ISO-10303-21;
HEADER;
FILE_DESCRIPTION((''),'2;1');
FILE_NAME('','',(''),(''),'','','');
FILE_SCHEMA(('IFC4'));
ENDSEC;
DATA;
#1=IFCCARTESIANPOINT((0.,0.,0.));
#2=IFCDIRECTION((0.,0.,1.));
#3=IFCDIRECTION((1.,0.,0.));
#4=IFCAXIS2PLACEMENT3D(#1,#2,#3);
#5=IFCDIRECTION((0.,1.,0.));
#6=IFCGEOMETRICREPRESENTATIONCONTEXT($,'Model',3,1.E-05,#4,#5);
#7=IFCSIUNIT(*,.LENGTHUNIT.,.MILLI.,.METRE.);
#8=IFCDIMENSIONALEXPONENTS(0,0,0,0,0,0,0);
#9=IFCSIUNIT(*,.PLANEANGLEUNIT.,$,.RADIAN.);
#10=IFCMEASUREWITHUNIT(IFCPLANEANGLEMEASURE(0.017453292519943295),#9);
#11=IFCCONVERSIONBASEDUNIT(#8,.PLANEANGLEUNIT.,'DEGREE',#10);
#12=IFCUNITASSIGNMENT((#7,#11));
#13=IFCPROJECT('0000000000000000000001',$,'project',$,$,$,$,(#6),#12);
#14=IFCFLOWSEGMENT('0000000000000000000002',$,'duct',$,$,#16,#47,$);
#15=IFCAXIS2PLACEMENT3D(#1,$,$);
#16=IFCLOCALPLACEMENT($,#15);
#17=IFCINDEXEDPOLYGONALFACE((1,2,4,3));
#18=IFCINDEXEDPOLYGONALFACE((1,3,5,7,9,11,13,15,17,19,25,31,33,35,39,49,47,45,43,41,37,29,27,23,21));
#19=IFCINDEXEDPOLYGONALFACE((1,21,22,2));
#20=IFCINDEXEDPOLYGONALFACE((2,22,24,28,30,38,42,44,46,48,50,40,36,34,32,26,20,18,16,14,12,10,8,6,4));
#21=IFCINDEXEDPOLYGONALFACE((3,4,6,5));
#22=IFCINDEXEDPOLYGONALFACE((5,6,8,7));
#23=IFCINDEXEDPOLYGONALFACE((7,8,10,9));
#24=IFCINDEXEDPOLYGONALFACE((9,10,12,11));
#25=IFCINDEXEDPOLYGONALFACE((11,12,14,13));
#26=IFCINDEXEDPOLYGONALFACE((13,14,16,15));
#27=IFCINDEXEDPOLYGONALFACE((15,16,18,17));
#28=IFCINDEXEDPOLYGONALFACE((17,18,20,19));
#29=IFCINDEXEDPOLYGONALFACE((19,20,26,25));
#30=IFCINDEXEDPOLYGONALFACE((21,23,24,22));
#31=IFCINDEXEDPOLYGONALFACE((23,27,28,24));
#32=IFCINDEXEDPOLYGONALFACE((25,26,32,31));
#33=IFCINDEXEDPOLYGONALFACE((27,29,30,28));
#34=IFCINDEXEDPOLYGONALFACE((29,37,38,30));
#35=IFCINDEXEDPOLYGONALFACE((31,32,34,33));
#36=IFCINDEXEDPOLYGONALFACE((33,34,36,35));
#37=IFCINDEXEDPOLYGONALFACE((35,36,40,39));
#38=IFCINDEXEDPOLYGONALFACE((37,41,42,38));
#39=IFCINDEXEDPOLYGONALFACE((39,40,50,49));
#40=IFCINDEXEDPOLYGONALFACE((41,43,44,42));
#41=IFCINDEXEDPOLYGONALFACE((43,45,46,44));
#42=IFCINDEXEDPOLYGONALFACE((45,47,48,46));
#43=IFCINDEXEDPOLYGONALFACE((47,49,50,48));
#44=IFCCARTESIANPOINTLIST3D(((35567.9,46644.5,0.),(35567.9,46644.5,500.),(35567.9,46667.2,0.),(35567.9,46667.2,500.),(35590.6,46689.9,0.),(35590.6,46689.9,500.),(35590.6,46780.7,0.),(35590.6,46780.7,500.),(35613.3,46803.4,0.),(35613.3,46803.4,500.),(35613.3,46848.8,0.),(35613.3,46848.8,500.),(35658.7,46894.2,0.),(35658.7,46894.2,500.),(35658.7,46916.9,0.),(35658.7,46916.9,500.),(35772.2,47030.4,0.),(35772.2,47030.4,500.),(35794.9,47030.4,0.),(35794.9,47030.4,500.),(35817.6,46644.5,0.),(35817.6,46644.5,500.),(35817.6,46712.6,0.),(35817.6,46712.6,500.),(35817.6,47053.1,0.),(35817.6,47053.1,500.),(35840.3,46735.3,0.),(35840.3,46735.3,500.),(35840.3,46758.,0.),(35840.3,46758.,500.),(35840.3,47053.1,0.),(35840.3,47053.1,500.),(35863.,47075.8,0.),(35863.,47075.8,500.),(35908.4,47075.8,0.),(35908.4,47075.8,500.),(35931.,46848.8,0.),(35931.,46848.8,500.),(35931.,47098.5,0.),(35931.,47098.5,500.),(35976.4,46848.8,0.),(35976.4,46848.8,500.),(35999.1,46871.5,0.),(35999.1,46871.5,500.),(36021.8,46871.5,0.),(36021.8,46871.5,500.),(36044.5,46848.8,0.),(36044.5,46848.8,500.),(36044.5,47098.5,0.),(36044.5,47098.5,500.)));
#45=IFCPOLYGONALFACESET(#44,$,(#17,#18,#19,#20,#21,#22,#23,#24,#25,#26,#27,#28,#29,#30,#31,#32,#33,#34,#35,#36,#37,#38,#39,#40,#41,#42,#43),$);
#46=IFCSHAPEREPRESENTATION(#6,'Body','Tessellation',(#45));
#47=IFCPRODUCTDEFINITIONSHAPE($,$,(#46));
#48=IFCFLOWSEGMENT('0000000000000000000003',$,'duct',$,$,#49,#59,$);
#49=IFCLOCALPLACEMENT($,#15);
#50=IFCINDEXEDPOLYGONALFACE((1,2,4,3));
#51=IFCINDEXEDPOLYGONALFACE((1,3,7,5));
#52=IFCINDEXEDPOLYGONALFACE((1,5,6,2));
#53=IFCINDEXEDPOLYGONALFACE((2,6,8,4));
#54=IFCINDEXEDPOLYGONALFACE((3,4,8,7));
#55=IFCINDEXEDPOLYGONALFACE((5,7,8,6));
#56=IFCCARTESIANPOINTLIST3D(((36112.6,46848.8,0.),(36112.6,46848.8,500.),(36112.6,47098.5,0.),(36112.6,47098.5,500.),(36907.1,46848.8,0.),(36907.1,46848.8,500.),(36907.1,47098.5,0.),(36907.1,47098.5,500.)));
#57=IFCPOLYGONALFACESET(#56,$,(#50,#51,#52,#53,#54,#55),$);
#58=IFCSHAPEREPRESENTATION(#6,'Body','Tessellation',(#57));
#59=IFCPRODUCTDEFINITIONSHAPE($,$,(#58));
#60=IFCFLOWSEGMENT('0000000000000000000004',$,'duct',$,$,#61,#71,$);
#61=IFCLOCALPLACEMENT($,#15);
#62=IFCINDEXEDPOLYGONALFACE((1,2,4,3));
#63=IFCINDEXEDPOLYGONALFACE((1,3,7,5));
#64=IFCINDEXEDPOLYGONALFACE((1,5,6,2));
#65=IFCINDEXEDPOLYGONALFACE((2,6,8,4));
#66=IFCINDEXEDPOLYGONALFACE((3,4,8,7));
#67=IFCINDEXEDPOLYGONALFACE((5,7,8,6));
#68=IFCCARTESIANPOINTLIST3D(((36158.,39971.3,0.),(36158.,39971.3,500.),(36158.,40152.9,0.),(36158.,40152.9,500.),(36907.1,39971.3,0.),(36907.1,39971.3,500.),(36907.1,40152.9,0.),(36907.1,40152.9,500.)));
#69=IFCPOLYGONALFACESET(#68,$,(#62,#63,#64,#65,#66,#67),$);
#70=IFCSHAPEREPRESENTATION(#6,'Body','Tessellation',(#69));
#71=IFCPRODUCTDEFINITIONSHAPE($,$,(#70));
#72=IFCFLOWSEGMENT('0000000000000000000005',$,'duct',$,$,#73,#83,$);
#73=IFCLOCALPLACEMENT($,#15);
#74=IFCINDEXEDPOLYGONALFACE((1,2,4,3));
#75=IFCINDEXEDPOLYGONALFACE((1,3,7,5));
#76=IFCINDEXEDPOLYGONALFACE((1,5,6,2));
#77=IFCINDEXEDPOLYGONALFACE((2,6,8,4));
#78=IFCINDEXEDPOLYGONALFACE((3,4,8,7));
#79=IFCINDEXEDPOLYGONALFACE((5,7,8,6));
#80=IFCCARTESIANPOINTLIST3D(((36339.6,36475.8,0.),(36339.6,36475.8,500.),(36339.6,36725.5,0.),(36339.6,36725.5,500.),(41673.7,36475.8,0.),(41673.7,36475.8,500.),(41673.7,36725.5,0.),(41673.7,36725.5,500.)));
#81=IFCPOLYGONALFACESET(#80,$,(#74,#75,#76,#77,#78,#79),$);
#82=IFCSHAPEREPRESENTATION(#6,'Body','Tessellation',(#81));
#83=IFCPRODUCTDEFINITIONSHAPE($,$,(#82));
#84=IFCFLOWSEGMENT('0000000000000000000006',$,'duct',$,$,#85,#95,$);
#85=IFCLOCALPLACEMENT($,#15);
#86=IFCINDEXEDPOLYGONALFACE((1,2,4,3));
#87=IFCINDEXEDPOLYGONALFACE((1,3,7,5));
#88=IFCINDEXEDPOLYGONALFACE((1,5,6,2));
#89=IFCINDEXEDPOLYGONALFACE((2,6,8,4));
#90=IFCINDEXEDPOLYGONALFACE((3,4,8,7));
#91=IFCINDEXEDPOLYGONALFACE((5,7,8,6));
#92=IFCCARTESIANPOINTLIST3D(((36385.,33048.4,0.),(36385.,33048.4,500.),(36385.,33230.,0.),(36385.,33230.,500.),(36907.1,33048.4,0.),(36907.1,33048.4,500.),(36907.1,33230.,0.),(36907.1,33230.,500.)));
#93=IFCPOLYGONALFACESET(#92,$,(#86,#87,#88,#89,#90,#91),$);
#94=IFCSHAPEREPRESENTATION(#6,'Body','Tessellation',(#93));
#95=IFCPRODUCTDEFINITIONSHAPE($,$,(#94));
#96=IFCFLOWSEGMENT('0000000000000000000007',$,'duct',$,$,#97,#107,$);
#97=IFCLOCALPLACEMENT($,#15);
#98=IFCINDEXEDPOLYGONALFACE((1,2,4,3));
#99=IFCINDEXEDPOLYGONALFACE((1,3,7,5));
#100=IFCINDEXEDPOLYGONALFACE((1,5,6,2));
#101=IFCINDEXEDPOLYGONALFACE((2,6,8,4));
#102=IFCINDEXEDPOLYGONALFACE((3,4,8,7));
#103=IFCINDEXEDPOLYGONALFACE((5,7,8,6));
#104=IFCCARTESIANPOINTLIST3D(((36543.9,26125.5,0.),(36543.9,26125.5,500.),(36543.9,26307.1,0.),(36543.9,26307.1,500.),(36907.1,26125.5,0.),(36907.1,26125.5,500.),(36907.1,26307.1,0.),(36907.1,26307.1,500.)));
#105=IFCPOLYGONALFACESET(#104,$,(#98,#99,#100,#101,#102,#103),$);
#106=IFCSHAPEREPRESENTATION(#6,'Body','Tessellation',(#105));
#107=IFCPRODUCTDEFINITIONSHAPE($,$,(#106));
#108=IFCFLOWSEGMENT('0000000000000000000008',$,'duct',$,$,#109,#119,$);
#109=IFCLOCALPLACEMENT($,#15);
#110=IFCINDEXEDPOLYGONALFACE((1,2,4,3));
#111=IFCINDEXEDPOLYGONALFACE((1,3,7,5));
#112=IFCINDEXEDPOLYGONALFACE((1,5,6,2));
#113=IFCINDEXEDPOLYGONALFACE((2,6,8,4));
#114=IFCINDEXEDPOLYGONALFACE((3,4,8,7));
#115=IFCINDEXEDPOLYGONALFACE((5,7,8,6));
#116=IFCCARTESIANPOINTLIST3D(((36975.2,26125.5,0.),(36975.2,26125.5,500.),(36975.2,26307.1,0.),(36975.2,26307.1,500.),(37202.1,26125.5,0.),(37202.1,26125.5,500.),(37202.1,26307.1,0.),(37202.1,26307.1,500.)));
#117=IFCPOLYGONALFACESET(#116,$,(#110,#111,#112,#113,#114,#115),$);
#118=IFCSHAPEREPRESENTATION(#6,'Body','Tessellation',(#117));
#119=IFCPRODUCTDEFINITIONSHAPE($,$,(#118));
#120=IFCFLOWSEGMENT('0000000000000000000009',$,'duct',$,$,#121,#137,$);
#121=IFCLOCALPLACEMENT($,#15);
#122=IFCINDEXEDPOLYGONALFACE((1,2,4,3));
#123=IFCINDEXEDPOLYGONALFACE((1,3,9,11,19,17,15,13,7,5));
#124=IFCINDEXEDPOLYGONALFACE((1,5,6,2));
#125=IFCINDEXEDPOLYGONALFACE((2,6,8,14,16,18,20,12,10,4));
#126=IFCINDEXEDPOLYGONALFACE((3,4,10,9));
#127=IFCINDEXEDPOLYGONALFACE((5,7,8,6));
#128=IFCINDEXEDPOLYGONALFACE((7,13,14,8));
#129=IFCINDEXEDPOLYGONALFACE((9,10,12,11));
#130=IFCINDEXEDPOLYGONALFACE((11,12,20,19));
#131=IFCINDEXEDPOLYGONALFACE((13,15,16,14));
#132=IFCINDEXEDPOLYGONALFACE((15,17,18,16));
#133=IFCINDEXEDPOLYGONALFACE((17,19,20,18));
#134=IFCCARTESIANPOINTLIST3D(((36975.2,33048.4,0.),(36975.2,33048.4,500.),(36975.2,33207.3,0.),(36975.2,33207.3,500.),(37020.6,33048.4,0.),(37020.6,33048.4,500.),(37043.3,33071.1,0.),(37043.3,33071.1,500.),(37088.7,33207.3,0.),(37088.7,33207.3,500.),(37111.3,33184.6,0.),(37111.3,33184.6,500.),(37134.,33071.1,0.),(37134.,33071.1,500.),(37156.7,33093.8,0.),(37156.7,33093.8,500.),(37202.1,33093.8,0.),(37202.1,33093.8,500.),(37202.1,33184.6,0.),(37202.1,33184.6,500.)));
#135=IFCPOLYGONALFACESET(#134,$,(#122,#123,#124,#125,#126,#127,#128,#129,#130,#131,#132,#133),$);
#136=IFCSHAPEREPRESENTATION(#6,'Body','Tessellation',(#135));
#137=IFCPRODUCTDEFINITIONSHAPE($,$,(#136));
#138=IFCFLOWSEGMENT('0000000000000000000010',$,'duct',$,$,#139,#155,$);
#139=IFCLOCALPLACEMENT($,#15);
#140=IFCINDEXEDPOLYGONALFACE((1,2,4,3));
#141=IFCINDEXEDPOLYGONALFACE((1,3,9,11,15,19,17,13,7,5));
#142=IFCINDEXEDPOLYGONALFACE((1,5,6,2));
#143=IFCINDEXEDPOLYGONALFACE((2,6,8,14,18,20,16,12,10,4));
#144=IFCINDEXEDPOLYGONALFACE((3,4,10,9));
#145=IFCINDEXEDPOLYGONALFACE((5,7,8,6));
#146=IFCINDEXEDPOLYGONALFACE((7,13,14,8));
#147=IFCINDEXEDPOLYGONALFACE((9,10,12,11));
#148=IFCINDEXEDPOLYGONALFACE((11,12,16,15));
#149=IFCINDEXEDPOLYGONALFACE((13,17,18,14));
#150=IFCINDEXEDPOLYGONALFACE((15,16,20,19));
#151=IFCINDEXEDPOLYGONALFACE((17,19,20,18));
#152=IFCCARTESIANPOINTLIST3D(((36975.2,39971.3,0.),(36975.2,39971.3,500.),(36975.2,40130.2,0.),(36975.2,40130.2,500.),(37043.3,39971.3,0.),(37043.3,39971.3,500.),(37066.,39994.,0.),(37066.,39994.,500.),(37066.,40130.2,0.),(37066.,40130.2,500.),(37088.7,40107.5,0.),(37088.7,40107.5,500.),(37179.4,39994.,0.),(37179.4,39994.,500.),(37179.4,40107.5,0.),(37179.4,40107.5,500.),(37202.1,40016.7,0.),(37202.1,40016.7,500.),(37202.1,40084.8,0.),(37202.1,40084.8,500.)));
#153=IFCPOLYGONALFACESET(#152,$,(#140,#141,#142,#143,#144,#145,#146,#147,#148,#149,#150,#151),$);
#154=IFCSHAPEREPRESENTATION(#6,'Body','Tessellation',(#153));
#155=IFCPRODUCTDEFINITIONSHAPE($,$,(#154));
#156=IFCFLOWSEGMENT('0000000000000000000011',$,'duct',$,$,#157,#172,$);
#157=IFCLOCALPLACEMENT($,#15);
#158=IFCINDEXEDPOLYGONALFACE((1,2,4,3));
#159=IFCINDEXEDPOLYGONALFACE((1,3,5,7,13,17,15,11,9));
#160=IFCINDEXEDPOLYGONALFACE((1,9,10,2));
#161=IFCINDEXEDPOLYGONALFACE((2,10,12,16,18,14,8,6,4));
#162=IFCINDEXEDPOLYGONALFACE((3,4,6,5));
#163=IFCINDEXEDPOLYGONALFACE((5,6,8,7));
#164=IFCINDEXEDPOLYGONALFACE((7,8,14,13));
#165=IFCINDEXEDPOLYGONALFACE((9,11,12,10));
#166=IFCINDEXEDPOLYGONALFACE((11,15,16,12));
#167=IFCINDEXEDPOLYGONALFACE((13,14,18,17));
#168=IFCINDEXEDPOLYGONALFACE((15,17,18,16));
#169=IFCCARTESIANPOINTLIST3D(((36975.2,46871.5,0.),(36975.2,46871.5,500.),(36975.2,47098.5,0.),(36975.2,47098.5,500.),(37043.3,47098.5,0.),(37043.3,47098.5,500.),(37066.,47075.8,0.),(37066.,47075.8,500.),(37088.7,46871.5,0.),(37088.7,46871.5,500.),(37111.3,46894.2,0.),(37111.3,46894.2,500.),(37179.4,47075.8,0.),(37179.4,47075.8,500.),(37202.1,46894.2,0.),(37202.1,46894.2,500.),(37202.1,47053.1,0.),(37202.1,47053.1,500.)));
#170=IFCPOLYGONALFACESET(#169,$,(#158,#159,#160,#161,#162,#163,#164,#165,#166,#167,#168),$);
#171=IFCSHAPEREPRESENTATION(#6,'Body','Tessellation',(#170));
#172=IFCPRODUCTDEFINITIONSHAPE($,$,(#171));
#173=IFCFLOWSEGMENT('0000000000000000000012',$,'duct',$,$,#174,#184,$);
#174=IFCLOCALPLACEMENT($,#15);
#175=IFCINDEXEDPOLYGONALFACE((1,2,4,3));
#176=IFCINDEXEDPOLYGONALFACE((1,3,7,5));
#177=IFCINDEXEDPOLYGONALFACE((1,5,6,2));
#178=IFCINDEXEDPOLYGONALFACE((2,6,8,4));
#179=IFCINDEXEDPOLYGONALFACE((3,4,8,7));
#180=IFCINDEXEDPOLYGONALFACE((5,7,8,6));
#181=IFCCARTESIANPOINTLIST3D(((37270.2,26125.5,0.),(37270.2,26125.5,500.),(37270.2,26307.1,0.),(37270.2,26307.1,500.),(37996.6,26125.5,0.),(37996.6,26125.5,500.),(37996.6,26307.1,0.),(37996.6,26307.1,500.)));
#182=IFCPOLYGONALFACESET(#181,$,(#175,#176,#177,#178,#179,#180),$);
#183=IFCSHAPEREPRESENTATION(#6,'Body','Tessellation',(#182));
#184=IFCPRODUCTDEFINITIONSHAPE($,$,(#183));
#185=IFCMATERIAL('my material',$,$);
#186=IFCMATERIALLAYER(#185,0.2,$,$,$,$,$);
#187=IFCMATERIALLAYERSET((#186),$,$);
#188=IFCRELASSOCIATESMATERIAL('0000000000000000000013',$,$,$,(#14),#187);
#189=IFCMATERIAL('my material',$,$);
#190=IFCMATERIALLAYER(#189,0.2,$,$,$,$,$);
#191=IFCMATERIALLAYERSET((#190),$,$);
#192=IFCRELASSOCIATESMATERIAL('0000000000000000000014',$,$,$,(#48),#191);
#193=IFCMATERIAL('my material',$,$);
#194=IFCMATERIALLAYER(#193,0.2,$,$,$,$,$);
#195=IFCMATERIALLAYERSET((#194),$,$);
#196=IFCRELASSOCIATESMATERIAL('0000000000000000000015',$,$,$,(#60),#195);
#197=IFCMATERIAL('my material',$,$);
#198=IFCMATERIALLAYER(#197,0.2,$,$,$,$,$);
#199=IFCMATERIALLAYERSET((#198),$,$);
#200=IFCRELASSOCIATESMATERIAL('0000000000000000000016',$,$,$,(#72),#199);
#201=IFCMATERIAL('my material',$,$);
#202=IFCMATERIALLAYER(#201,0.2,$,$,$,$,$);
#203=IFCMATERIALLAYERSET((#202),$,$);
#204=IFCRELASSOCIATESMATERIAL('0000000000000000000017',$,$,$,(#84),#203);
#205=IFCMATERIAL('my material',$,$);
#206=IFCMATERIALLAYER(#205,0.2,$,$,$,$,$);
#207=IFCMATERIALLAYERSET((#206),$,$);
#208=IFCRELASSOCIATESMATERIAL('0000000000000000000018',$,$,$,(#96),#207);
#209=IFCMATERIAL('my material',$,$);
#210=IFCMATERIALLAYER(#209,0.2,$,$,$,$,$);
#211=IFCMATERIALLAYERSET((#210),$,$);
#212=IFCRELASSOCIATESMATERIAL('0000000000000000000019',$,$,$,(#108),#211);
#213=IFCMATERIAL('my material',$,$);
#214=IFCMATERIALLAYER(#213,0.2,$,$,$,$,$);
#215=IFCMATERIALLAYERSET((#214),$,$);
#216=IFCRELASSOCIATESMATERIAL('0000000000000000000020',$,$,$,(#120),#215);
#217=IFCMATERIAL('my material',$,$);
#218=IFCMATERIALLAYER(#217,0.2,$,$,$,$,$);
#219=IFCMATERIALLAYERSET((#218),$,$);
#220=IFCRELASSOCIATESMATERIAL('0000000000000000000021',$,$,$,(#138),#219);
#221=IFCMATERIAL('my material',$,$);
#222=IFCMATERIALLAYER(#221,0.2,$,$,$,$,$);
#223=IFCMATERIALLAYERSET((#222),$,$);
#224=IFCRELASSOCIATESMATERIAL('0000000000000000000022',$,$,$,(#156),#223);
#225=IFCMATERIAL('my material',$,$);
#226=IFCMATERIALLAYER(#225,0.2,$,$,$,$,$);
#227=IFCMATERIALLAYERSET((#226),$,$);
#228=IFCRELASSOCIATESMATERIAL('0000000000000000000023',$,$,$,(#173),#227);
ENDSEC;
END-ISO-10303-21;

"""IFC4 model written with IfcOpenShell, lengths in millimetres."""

from ifc_helpers import new_model, entity, si_unit, converted_unit, direction, origin_with_axes, place, context, project, polyline, outline, extrude, material, layer, layer_set, layer_usage, element, save


model = new_model("IFC4")

# Units and contexts
model_context = context("Model", 3, precision=1e-05, world=origin_with_axes(), true_north=direction((0.0, 1.0, 0.0)))
ifc_project = project(units=[si_unit("LENGTHUNIT", "METRE", prefix="MILLI"), converted_unit("PLANEANGLEUNIT", "DEGREE", entity("IfcPlaneAngleMeasure", 0.017453292519943295), si_unit("PLANEANGLEUNIT", "RADIAN"), dimensions=[0, 0, 0, 0, 0, 0, 0])], contexts=[model_context])

# Flow segments
ifc_material_1 = material(Name="my material")
ifc_layer_1 = layer(ifc_material_1, 0.2)
ifc_layer_set_1 = layer_set([ifc_layer_1])
ifc_layer_usage_1 = layer_usage(ifc_layer_set_1, "AXIS2", "POSITIVE", -0.1)
flow_segment_1_placement = place(None, origin_with_axes())
element("IfcFlowSegment", 1, at=flow_segment_1_placement, material=ifc_layer_usage_1, Name="duct", context=model_context, shape_type="SweptSolid", body=[
    extrude(outline(polyline([(35567.9, 46644.5), (35817.6, 46644.5), (35817.6, 46712.6), (35840.3, 46735.3), (35840.3, 46758.0), (35931.0, 46848.8), (35976.4, 46848.8), (35999.1, 46871.5), (36021.8, 46871.5), (36044.5, 46848.8), (36044.5, 47098.5), (35931.0, 47098.5), (35908.4, 47075.8), (35863.0, 47075.8), (35840.3, 47053.1), (35817.6, 47053.1), (35794.9, 47030.4), (35772.2, 47030.4), (35658.7, 46916.9), (35658.7, 46894.2), (35613.3, 46848.8), (35613.3, 46803.4), (35590.6, 46780.7), (35590.6, 46689.9), (35567.9, 46667.2), (35567.9, 46644.5)])), origin_with_axes(), (0.0, 0.0, 1.0), 500.0),
])
ifc_material_2 = material(Name="my material")
ifc_layer_2 = layer(ifc_material_2, 0.2)
ifc_layer_set_2 = layer_set([ifc_layer_2])
ifc_layer_usage_2 = layer_usage(ifc_layer_set_2, "AXIS2", "POSITIVE", -0.1)
flow_segment_2_placement = place(None, origin_with_axes())
element("IfcFlowSegment", 2, at=flow_segment_2_placement, material=ifc_layer_usage_2, Name="duct", context=model_context, shape_type="SweptSolid", body=[
    extrude(outline(polyline([(36112.6, 46848.8), (36907.1, 46848.8), (36907.1, 47098.5), (36112.6, 47098.5), (36112.6, 46848.8)])), origin_with_axes(), (0.0, 0.0, 1.0), 500.0),
])
ifc_material_3 = material(Name="my material")
ifc_layer_3 = layer(ifc_material_3, 0.2)
ifc_layer_set_3 = layer_set([ifc_layer_3])
ifc_layer_usage_3 = layer_usage(ifc_layer_set_3, "AXIS2", "POSITIVE", -0.1)
flow_segment_3_placement = place(None, origin_with_axes())
element("IfcFlowSegment", 3, at=flow_segment_3_placement, material=ifc_layer_usage_3, Name="duct", context=model_context, shape_type="SweptSolid", body=[
    extrude(outline(polyline([(36158.0, 39971.3), (36907.1, 39971.3), (36907.1, 40152.9), (36158.0, 40152.9), (36158.0, 39971.3)])), origin_with_axes(), (0.0, 0.0, 1.0), 500.0),
])
ifc_material_4 = material(Name="my material")
ifc_layer_4 = layer(ifc_material_4, 0.2)
ifc_layer_set_4 = layer_set([ifc_layer_4])
ifc_layer_usage_4 = layer_usage(ifc_layer_set_4, "AXIS2", "POSITIVE", -0.1)
flow_segment_4_placement = place(None, origin_with_axes())
element("IfcFlowSegment", 4, at=flow_segment_4_placement, material=ifc_layer_usage_4, Name="duct", context=model_context, shape_type="SweptSolid", body=[
    extrude(outline(polyline([(36339.6, 36475.8), (41673.7, 36475.8), (41673.7, 36725.5), (36339.6, 36725.5), (36339.6, 36475.8)])), origin_with_axes(), (0.0, 0.0, 1.0), 500.0),
])
ifc_material_5 = material(Name="my material")
ifc_layer_5 = layer(ifc_material_5, 0.2)
ifc_layer_set_5 = layer_set([ifc_layer_5])
ifc_layer_usage_5 = layer_usage(ifc_layer_set_5, "AXIS2", "POSITIVE", -0.1)
flow_segment_5_placement = place(None, origin_with_axes())
element("IfcFlowSegment", 5, at=flow_segment_5_placement, material=ifc_layer_usage_5, Name="duct", context=model_context, shape_type="SweptSolid", body=[
    extrude(outline(polyline([(36385.0, 33048.4), (36907.1, 33048.4), (36907.1, 33230.0), (36385.0, 33230.0), (36385.0, 33048.4)])), origin_with_axes(), (0.0, 0.0, 1.0), 500.0),
])
ifc_material_6 = material(Name="my material")
ifc_layer_6 = layer(ifc_material_6, 0.2)
ifc_layer_set_6 = layer_set([ifc_layer_6])
ifc_layer_usage_6 = layer_usage(ifc_layer_set_6, "AXIS2", "POSITIVE", -0.1)
flow_segment_6_placement = place(None, origin_with_axes())
element("IfcFlowSegment", 6, at=flow_segment_6_placement, material=ifc_layer_usage_6, Name="duct", context=model_context, shape_type="SweptSolid", body=[
    extrude(outline(polyline([(36543.9, 26125.5), (36907.1, 26125.5), (36907.1, 26307.1), (36543.9, 26307.1), (36543.9, 26125.5)])), origin_with_axes(), (0.0, 0.0, 1.0), 500.0),
])
ifc_material_7 = material(Name="my material")
ifc_layer_7 = layer(ifc_material_7, 0.2)
ifc_layer_set_7 = layer_set([ifc_layer_7])
ifc_layer_usage_7 = layer_usage(ifc_layer_set_7, "AXIS2", "POSITIVE", -0.1)
flow_segment_7_placement = place(None, origin_with_axes())
element("IfcFlowSegment", 7, at=flow_segment_7_placement, material=ifc_layer_usage_7, Name="duct", context=model_context, shape_type="SweptSolid", body=[
    extrude(outline(polyline([(36975.2, 26125.5), (37202.1, 26125.5), (37202.1, 26307.1), (36975.2, 26307.1), (36975.2, 26125.5)])), origin_with_axes(), (0.0, 0.0, 1.0), 500.0),
])
ifc_material_8 = material(Name="my material")
ifc_layer_8 = layer(ifc_material_8, 0.2)
ifc_layer_set_8 = layer_set([ifc_layer_8])
ifc_layer_usage_8 = layer_usage(ifc_layer_set_8, "AXIS2", "POSITIVE", -0.1)
flow_segment_8_placement = place(None, origin_with_axes())
element("IfcFlowSegment", 8, at=flow_segment_8_placement, material=ifc_layer_usage_8, Name="duct", context=model_context, shape_type="SweptSolid", body=[
    extrude(outline(polyline([(36975.2, 33048.4), (37020.6, 33048.4), (37043.3, 33071.1), (37134.0, 33071.1), (37156.7, 33093.8), (37202.1, 33093.8), (37202.1, 33184.6), (37111.3, 33184.6), (37088.7, 33207.3), (36975.2, 33207.3), (36975.2, 33048.4)])), origin_with_axes(), (0.0, 0.0, 1.0), 500.0),
])
ifc_material_9 = material(Name="my material")
ifc_layer_9 = layer(ifc_material_9, 0.2)
ifc_layer_set_9 = layer_set([ifc_layer_9])
ifc_layer_usage_9 = layer_usage(ifc_layer_set_9, "AXIS2", "POSITIVE", -0.1)
flow_segment_9_placement = place(None, origin_with_axes())
element("IfcFlowSegment", 9, at=flow_segment_9_placement, material=ifc_layer_usage_9, Name="duct", context=model_context, shape_type="SweptSolid", body=[
    extrude(outline(polyline([(36975.2, 39971.3), (37043.3, 39971.3), (37066.0, 39994.0), (37179.4, 39994.0), (37202.1, 40016.7), (37202.1, 40084.8), (37179.4, 40107.5), (37088.7, 40107.5), (37066.0, 40130.2), (36975.2, 40130.2), (36975.2, 39971.3)])), origin_with_axes(), (0.0, 0.0, 1.0), 500.0),
])
ifc_material_10 = material(Name="my material")
ifc_layer_10 = layer(ifc_material_10, 0.2)
ifc_layer_set_10 = layer_set([ifc_layer_10])
ifc_layer_usage_10 = layer_usage(ifc_layer_set_10, "AXIS2", "POSITIVE", -0.1)
flow_segment_10_placement = place(None, origin_with_axes())
element("IfcFlowSegment", 10, at=flow_segment_10_placement, material=ifc_layer_usage_10, Name="duct", context=model_context, shape_type="SweptSolid", body=[
    extrude(outline(polyline([(36975.2, 46871.5), (37088.7, 46871.5), (37111.3, 46894.2), (37202.1, 46894.2), (37202.1, 47053.1), (37179.4, 47075.8), (37066.0, 47075.8), (37043.3, 47098.5), (36975.2, 47098.5), (36975.2, 46871.5)])), origin_with_axes(), (0.0, 0.0, 1.0), 500.0),
])
ifc_material_11 = material(Name="my material")
ifc_layer_11 = layer(ifc_material_11, 0.2)
ifc_layer_set_11 = layer_set([ifc_layer_11])
ifc_layer_usage_11 = layer_usage(ifc_layer_set_11, "AXIS2", "POSITIVE", -0.1)
flow_segment_11_placement = place(None, origin_with_axes())
element("IfcFlowSegment", 11, at=flow_segment_11_placement, material=ifc_layer_usage_11, Name="duct", context=model_context, shape_type="SweptSolid", body=[
    extrude(outline(polyline([(37270.2, 26125.5), (37996.6, 26125.5), (37996.6, 26307.1), (37270.2, 26307.1), (37270.2, 26125.5)])), origin_with_axes(), (0.0, 0.0, 1.0), 500.0),
])

save(model, "model.ifc")
